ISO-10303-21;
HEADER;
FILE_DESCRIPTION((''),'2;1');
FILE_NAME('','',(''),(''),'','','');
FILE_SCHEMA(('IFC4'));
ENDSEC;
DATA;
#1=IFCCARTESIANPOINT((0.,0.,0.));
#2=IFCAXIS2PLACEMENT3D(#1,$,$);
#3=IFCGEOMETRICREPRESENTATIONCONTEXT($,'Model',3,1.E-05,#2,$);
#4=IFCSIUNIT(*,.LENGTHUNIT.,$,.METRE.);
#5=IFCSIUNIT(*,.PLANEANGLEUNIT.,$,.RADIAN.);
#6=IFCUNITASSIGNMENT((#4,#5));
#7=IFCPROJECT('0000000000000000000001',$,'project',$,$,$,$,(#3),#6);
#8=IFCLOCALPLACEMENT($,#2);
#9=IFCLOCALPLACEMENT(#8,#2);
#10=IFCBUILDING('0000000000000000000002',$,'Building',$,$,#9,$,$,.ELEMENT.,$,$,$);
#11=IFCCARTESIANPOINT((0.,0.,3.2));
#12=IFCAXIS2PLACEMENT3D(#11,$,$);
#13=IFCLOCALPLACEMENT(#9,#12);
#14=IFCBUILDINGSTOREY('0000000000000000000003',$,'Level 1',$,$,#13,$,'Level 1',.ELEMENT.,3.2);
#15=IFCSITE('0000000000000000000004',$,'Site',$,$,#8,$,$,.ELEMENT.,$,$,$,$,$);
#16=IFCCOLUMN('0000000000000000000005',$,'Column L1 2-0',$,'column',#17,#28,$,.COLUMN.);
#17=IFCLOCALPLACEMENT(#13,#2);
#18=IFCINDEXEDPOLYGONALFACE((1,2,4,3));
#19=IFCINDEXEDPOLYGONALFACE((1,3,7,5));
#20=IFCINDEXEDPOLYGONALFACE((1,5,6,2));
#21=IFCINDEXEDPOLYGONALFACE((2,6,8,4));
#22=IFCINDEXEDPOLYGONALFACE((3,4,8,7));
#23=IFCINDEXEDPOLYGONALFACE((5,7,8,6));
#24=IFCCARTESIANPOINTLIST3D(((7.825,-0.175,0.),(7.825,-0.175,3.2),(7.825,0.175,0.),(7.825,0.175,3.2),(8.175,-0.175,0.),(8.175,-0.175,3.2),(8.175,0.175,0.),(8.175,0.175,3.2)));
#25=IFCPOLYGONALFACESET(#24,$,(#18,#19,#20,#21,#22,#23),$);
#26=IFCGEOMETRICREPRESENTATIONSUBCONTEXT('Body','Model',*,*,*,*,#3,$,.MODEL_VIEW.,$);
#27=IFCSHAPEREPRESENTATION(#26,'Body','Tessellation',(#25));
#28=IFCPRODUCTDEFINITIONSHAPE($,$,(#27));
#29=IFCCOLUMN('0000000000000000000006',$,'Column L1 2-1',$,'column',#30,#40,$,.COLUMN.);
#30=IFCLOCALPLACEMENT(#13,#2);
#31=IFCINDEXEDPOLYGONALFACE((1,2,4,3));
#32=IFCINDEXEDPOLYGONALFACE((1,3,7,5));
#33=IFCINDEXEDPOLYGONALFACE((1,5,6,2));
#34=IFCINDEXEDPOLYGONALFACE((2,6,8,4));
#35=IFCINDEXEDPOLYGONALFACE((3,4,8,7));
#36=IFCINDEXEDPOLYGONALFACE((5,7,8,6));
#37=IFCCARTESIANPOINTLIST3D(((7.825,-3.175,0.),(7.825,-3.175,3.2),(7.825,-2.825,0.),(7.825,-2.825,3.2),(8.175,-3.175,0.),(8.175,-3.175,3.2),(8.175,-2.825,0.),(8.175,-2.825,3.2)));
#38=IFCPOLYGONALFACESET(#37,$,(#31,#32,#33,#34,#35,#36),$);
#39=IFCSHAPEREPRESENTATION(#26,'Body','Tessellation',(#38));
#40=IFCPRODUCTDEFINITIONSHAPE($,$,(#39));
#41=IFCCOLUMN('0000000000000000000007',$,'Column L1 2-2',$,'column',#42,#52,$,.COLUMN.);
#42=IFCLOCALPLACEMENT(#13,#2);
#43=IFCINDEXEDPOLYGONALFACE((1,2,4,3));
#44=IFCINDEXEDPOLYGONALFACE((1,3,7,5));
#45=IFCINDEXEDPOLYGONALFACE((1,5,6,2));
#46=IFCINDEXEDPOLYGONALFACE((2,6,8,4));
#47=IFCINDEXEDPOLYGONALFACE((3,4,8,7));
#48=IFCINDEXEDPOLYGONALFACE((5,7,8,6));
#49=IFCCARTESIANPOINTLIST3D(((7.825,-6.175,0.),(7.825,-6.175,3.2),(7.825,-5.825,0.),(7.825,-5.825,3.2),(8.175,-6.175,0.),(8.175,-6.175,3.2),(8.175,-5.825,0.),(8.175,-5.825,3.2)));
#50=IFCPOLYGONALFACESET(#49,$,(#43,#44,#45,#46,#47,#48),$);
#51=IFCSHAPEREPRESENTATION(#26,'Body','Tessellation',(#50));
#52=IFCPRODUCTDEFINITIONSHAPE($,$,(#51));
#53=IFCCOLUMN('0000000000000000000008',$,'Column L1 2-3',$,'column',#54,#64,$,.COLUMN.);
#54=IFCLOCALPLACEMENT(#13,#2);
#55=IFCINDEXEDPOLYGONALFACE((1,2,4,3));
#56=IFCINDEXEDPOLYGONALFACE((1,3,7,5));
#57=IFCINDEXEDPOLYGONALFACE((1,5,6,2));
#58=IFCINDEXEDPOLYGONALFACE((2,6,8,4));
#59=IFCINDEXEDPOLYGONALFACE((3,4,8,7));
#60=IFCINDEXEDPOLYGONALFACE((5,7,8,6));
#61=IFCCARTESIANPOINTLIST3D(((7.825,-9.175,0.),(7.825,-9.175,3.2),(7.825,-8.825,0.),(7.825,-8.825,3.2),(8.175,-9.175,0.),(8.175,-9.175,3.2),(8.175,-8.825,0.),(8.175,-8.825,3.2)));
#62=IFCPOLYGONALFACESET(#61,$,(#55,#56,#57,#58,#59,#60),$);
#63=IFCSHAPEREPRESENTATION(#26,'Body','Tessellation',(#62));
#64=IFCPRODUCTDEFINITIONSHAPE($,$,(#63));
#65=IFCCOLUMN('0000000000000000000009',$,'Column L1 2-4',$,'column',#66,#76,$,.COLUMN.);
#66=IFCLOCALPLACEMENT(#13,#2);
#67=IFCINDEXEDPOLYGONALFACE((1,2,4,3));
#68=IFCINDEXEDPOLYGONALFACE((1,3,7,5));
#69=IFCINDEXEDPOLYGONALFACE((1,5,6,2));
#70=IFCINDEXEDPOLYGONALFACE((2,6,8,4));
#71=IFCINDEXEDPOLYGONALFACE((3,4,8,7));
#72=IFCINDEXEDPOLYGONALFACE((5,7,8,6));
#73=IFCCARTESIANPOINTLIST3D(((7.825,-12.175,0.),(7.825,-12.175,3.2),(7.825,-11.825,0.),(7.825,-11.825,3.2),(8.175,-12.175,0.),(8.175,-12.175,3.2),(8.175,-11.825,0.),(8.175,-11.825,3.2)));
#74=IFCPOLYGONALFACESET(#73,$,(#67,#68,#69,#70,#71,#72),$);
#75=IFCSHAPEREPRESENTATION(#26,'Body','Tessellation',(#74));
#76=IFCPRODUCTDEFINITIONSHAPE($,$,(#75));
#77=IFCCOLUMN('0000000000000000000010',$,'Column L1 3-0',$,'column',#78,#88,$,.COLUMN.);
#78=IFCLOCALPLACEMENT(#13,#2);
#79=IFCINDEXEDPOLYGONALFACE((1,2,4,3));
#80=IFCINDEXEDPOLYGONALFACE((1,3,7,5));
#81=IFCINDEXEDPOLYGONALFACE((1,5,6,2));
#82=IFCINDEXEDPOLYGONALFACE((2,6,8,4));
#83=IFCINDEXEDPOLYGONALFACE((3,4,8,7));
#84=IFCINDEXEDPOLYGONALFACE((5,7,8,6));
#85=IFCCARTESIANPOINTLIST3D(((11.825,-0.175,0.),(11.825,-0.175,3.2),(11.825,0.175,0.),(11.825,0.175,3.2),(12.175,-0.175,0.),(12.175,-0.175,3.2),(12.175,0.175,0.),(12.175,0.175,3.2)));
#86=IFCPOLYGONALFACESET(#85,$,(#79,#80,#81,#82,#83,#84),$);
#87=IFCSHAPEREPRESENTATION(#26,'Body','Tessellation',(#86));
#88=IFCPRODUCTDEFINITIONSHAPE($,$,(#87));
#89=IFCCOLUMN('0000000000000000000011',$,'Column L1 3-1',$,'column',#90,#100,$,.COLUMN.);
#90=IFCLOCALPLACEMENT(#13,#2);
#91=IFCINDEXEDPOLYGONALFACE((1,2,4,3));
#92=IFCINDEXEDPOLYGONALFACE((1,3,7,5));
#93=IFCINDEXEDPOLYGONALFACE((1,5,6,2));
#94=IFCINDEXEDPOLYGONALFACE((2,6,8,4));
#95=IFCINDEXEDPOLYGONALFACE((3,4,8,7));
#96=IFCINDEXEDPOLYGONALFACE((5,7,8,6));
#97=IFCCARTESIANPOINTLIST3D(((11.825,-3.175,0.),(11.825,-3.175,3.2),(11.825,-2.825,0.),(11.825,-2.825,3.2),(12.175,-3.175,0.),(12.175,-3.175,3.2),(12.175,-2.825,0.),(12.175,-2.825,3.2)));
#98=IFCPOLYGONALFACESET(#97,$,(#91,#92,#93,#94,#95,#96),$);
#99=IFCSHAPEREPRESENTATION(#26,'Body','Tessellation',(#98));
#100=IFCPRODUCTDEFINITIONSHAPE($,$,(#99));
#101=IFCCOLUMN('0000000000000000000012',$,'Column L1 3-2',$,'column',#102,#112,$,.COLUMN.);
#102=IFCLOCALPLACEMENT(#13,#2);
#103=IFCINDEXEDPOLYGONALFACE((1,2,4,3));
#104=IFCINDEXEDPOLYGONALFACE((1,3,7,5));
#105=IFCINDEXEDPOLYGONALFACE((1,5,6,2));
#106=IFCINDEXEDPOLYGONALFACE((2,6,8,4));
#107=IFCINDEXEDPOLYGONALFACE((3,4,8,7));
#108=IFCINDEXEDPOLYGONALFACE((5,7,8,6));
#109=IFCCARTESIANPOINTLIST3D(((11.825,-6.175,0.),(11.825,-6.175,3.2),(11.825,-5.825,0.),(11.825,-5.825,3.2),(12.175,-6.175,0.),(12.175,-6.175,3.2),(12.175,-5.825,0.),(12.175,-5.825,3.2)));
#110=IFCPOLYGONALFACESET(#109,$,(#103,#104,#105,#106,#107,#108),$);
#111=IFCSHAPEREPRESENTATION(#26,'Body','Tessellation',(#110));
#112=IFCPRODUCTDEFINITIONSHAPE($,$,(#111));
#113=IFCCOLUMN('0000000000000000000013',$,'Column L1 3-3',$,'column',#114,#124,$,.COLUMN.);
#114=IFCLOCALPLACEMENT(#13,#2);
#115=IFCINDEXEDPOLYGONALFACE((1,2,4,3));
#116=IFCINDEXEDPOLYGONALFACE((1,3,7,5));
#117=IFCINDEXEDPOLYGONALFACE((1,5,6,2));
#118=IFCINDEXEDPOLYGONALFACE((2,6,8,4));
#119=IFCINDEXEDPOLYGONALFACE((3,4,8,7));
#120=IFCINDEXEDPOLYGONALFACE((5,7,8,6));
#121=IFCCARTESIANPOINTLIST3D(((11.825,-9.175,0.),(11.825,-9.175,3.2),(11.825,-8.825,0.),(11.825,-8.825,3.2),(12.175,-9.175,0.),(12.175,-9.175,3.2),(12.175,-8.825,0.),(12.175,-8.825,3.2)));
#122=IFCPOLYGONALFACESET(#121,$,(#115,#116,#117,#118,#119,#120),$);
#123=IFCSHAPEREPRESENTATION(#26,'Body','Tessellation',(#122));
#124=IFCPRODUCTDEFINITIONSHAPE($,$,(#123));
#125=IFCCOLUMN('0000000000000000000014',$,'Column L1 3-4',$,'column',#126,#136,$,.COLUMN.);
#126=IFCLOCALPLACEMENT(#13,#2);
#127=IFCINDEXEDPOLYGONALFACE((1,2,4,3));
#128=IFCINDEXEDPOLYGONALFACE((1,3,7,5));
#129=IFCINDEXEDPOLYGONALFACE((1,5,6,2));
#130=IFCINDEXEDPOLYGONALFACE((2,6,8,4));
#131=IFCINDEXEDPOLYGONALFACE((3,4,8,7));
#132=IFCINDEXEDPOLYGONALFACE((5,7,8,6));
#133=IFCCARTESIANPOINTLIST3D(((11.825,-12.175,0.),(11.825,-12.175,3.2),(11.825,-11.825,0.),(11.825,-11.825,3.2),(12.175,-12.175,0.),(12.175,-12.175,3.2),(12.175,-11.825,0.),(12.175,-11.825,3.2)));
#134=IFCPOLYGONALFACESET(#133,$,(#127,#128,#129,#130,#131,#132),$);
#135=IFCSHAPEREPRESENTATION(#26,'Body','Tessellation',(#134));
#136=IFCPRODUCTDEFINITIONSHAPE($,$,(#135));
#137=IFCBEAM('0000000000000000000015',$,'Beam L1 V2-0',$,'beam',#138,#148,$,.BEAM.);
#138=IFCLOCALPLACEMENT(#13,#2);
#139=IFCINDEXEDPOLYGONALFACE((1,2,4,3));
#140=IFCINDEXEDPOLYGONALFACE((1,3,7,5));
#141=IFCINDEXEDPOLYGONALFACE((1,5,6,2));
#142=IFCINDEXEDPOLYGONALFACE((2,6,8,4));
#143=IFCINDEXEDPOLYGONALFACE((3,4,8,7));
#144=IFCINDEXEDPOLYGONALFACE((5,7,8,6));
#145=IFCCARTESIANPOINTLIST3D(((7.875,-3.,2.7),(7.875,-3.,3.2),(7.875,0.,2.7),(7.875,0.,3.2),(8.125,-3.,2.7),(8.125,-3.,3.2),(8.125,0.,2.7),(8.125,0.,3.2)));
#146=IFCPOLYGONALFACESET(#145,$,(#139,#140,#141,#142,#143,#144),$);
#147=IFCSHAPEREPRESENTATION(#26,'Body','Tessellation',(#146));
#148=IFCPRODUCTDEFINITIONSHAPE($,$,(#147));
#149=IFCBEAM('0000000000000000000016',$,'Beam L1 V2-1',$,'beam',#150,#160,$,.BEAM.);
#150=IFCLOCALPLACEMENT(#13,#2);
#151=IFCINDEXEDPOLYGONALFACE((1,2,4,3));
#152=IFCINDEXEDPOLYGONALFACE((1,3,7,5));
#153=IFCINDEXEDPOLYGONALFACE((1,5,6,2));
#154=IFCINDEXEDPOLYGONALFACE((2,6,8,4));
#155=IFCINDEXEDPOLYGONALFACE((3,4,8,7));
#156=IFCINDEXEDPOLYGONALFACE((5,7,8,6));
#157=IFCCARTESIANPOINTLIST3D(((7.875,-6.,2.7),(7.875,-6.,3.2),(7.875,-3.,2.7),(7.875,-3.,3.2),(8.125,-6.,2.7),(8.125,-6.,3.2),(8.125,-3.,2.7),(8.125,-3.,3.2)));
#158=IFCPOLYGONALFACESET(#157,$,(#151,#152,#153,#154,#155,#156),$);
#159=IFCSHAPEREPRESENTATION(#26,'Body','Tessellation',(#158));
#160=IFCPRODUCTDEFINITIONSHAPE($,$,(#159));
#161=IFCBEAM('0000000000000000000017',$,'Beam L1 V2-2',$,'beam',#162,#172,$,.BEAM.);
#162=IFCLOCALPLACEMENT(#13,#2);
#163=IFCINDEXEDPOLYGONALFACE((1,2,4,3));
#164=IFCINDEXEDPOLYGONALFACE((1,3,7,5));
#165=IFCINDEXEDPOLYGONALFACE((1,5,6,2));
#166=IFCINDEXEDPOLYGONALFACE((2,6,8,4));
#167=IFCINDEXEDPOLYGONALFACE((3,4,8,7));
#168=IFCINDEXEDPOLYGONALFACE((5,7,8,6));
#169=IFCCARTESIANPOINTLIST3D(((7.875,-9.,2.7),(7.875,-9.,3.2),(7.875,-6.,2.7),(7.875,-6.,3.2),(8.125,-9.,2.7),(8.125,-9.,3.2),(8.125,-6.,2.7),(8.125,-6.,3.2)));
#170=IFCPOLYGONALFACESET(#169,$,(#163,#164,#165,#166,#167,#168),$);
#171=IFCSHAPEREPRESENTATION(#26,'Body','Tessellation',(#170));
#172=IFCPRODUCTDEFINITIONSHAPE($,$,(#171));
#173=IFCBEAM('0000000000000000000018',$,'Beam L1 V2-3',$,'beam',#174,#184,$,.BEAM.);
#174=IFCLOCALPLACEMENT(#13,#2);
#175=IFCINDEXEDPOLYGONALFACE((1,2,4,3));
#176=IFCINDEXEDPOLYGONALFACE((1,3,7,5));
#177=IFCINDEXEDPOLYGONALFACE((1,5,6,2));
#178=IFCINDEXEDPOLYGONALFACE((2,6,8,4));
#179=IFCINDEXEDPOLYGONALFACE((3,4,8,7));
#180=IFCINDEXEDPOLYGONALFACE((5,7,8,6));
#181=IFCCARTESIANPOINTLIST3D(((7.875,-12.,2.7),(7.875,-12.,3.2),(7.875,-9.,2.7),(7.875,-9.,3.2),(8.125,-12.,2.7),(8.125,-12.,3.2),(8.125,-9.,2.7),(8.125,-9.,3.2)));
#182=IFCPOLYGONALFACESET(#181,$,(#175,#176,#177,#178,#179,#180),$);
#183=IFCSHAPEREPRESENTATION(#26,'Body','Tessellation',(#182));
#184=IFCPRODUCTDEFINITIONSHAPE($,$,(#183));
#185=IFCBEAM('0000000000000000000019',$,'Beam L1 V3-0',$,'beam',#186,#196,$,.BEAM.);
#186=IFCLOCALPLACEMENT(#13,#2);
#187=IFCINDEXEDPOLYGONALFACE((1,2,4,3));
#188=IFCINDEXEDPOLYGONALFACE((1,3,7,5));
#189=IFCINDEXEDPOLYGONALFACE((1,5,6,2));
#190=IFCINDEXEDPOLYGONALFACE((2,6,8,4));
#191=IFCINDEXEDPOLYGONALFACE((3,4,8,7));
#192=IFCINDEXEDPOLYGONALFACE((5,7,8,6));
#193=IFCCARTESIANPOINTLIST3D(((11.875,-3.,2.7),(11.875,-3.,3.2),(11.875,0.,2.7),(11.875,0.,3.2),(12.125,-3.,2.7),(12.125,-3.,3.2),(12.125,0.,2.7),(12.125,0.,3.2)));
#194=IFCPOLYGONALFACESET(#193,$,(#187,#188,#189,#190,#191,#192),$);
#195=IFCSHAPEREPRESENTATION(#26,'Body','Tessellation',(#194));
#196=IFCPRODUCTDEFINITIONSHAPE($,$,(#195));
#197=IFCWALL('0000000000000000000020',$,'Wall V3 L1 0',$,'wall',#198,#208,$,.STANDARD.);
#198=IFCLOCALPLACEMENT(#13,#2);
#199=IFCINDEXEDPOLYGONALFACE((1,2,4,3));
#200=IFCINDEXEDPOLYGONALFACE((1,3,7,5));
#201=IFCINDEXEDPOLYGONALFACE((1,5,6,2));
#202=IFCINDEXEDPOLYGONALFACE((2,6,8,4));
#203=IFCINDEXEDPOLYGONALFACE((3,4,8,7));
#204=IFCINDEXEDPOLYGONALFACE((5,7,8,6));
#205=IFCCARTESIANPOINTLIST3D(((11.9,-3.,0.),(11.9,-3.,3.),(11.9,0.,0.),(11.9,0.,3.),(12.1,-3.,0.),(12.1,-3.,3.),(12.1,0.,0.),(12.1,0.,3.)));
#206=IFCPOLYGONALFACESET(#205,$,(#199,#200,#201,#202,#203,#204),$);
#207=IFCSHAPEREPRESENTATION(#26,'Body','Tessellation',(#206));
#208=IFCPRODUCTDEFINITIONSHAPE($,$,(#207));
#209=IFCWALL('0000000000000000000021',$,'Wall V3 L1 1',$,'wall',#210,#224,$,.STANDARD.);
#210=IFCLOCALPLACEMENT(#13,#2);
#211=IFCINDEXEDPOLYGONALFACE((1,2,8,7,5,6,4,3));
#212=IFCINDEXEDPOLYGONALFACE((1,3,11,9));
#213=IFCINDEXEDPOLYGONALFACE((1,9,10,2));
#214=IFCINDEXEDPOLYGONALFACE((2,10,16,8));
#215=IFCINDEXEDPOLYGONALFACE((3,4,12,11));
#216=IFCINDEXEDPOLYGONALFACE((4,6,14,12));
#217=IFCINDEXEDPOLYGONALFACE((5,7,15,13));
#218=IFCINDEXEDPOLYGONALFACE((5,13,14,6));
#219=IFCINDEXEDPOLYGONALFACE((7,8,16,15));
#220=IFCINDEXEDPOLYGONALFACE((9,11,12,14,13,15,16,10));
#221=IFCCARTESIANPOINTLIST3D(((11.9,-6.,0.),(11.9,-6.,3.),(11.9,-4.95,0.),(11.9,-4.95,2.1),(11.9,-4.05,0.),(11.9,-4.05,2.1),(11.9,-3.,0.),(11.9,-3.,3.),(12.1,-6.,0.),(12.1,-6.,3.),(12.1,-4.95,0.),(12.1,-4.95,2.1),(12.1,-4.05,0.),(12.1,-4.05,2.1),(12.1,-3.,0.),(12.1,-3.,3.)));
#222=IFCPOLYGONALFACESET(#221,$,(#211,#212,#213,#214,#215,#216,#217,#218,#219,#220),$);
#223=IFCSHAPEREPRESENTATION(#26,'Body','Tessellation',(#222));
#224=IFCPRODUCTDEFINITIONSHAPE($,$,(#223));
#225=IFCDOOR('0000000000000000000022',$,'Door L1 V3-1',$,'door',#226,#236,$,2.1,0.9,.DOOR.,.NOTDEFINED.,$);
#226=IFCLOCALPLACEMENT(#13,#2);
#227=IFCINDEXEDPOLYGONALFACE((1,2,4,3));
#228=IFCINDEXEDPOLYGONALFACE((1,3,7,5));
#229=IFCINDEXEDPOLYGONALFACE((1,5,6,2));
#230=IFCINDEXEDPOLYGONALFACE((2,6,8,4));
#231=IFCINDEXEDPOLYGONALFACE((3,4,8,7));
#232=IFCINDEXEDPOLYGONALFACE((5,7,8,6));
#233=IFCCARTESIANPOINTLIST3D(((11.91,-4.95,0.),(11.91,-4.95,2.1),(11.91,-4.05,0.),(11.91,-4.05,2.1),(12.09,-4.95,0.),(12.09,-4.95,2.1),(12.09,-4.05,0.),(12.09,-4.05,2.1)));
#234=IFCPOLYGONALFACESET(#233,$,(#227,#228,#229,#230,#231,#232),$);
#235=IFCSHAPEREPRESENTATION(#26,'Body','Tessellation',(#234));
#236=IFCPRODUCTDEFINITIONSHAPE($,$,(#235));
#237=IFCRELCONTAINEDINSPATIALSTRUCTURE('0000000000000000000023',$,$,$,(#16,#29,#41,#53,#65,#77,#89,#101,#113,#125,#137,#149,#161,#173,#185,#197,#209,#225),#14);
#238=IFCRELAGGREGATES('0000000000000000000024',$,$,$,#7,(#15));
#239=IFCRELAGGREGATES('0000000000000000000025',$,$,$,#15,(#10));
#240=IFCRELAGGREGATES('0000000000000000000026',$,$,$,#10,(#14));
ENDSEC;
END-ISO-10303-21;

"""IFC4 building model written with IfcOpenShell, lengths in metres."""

from ifc_helpers import new_model, si_unit, frame, frame_2d, origin, origin_2d, place, context, subcontext, project, spatial, rectangle, extrude, element, fill, save


model = new_model("IFC4")

# Units and contexts
model_context = context("Model", 3, precision=1e-05, world=origin())
body_context = subcontext(model_context, "Body", "Model", "MODEL_VIEW")
ifc_project = project(units=[si_unit("LENGTHUNIT", "METRE"), si_unit("PLANEANGLEUNIT", "RADIAN")], contexts=[model_context])

# Site, building, storey
site_placement = place(None, origin())
site = spatial("IfcSite", under=ifc_project, at=site_placement, Name="Site", CompositionType="ELEMENT")
building_placement = place(site_placement, origin())
building = spatial("IfcBuilding", under=site, at=building_placement, Name="Building", CompositionType="ELEMENT")
storey_placement = place(building_placement, frame((0.0, 0.0, 3.2)))
storey = spatial("IfcBuildingStorey", under=building, at=storey_placement, Name="Level 1", LongName="Level 1", CompositionType="ELEMENT", Elevation=3.2)

# Columns
for number, where, name in (
    (1, (8.0, 0.0, 0.0), "Column L1 2-0"),
    (2, (8.0, -3.0, 0.0), "Column L1 2-1"),
    (3, (8.0, -6.0, 0.0), "Column L1 2-2"),
    (4, (8.0, -9.0, 0.0), "Column L1 2-3"),
    (5, (8.0, -12.0, 0.0), "Column L1 2-4"),
    (6, (12.0, 0.0, 0.0), "Column L1 3-0"),
    (7, (12.0, -3.0, 0.0), "Column L1 3-1"),
    (8, (12.0, -6.0, 0.0), "Column L1 3-2"),
    (9, (12.0, -9.0, 0.0), "Column L1 3-3"),
    (10, (12.0, -12.0, 0.0), "Column L1 3-4"),
):
    element("IfcColumn", number, at=place(storey_placement, frame(where)), inside=storey, Name=name, ObjectType="column", PredefinedType="COLUMN", context=body_context, shape_type="SweptSolid", body=[
        extrude(rectangle(XDim=0.35, YDim=0.35, at=origin_2d()), origin(), (0.0, 0.0, 1.0), 3.2),
    ])

# Beams
for number, where, z_axis, x_axis, name in (
    (11, (8.0, 0.0, 2.95), (0.0, -1.0, 0.0), (0.0, 0.0, 1.0), "Beam L1 V2-0"),
    (12, (8.0, -3.0, 2.95), (0.0, -1.0, 0.0), (0.0, 0.0, 1.0), "Beam L1 V2-1"),
    (13, (8.0, -6.0, 2.95), (0.0, -1.0, 0.0), (0.0, 0.0, 1.0), "Beam L1 V2-2"),
    (14, (8.0, -9.0, 2.95), (0.0, -1.0, 0.0), (0.0, 0.0, 1.0), "Beam L1 V2-3"),
    (15, (12.0, 0.0, 2.95), (0.0, -1.0, 0.0), (0.0, 0.0, 1.0), "Beam L1 V3-0"),
):
    element("IfcBeam", number, at=place(storey_placement, frame(where, z_axis=z_axis, x_axis=x_axis)), inside=storey, Name=name, ObjectType="beam", PredefinedType="BEAM", context=body_context, shape_type="SweptSolid", body=[
        extrude(rectangle(XDim=0.5, YDim=0.25, at=origin_2d()), origin(), (0.0, 0.0, 1.0), 3.0),
    ])

# Wall
wall_1_placement = place(storey_placement, frame((12.0, 0.0, 0.0), z_axis=(0.0, 0.0, 1.0), x_axis=(0.0, -1.0, 0.0)))
element("IfcWall", 16, at=wall_1_placement, inside=storey, Name="Wall V3 L1 0", ObjectType="wall", PredefinedType="STANDARD", context=body_context, shape_type="SweptSolid", body=[
    extrude(rectangle(XDim=3.0, YDim=0.2, at=frame_2d((1.5, 0.0))), origin(), (0.0, 0.0, 1.0), 3.0),
])

# Wall, opening, door
wall_2_placement = place(storey_placement, frame((12.0, -3.0, 0.0), z_axis=(0.0, 0.0, 1.0), x_axis=(0.0, -1.0, 0.0)))
wall_2 = element("IfcWall", 17, at=wall_2_placement, inside=storey, Name="Wall V3 L1 1", ObjectType="wall", PredefinedType="STANDARD", context=body_context, shape_type="SweptSolid", body=[
    extrude(rectangle(XDim=3.0, YDim=0.2, at=frame_2d((1.5, 0.0))), origin(), (0.0, 0.0, 1.0), 3.0),
])
opening_1_placement = place(storey_placement, frame((12.0, -4.5, 0.0), z_axis=(0.0, 0.0, 1.0), x_axis=(0.0, -1.0, 0.0)))
opening_1 = element("IfcOpeningElement", 18, at=opening_1_placement, cuts=wall_2, ObjectType="Opening", PredefinedType="OPENING", context=body_context, shape_type="SweptSolid", body=[
    extrude(rectangle(XDim=0.9, YDim=0.22, at=origin_2d()), origin(), (0.0, 0.0, 1.0), 2.1),
])
door_1_placement = place(storey_placement, frame((12.0, -4.5, 0.0), z_axis=(0.0, 0.0, 1.0), x_axis=(0.0, -1.0, 0.0)))
door_1 = element("IfcDoor", 19, at=door_1_placement, inside=storey, Name="Door L1 V3-1", ObjectType="door", OperationType="NOTDEFINED", OverallHeight=2.1, OverallWidth=0.9, PredefinedType="DOOR", context=body_context, shape_type="SweptSolid", body=[
    extrude(rectangle(XDim=0.9, YDim=0.18, at=origin_2d()), origin(), (0.0, 0.0, 1.0), 2.1),
])
fill(opening_1, door_1)

save(model, "model.ifc")
